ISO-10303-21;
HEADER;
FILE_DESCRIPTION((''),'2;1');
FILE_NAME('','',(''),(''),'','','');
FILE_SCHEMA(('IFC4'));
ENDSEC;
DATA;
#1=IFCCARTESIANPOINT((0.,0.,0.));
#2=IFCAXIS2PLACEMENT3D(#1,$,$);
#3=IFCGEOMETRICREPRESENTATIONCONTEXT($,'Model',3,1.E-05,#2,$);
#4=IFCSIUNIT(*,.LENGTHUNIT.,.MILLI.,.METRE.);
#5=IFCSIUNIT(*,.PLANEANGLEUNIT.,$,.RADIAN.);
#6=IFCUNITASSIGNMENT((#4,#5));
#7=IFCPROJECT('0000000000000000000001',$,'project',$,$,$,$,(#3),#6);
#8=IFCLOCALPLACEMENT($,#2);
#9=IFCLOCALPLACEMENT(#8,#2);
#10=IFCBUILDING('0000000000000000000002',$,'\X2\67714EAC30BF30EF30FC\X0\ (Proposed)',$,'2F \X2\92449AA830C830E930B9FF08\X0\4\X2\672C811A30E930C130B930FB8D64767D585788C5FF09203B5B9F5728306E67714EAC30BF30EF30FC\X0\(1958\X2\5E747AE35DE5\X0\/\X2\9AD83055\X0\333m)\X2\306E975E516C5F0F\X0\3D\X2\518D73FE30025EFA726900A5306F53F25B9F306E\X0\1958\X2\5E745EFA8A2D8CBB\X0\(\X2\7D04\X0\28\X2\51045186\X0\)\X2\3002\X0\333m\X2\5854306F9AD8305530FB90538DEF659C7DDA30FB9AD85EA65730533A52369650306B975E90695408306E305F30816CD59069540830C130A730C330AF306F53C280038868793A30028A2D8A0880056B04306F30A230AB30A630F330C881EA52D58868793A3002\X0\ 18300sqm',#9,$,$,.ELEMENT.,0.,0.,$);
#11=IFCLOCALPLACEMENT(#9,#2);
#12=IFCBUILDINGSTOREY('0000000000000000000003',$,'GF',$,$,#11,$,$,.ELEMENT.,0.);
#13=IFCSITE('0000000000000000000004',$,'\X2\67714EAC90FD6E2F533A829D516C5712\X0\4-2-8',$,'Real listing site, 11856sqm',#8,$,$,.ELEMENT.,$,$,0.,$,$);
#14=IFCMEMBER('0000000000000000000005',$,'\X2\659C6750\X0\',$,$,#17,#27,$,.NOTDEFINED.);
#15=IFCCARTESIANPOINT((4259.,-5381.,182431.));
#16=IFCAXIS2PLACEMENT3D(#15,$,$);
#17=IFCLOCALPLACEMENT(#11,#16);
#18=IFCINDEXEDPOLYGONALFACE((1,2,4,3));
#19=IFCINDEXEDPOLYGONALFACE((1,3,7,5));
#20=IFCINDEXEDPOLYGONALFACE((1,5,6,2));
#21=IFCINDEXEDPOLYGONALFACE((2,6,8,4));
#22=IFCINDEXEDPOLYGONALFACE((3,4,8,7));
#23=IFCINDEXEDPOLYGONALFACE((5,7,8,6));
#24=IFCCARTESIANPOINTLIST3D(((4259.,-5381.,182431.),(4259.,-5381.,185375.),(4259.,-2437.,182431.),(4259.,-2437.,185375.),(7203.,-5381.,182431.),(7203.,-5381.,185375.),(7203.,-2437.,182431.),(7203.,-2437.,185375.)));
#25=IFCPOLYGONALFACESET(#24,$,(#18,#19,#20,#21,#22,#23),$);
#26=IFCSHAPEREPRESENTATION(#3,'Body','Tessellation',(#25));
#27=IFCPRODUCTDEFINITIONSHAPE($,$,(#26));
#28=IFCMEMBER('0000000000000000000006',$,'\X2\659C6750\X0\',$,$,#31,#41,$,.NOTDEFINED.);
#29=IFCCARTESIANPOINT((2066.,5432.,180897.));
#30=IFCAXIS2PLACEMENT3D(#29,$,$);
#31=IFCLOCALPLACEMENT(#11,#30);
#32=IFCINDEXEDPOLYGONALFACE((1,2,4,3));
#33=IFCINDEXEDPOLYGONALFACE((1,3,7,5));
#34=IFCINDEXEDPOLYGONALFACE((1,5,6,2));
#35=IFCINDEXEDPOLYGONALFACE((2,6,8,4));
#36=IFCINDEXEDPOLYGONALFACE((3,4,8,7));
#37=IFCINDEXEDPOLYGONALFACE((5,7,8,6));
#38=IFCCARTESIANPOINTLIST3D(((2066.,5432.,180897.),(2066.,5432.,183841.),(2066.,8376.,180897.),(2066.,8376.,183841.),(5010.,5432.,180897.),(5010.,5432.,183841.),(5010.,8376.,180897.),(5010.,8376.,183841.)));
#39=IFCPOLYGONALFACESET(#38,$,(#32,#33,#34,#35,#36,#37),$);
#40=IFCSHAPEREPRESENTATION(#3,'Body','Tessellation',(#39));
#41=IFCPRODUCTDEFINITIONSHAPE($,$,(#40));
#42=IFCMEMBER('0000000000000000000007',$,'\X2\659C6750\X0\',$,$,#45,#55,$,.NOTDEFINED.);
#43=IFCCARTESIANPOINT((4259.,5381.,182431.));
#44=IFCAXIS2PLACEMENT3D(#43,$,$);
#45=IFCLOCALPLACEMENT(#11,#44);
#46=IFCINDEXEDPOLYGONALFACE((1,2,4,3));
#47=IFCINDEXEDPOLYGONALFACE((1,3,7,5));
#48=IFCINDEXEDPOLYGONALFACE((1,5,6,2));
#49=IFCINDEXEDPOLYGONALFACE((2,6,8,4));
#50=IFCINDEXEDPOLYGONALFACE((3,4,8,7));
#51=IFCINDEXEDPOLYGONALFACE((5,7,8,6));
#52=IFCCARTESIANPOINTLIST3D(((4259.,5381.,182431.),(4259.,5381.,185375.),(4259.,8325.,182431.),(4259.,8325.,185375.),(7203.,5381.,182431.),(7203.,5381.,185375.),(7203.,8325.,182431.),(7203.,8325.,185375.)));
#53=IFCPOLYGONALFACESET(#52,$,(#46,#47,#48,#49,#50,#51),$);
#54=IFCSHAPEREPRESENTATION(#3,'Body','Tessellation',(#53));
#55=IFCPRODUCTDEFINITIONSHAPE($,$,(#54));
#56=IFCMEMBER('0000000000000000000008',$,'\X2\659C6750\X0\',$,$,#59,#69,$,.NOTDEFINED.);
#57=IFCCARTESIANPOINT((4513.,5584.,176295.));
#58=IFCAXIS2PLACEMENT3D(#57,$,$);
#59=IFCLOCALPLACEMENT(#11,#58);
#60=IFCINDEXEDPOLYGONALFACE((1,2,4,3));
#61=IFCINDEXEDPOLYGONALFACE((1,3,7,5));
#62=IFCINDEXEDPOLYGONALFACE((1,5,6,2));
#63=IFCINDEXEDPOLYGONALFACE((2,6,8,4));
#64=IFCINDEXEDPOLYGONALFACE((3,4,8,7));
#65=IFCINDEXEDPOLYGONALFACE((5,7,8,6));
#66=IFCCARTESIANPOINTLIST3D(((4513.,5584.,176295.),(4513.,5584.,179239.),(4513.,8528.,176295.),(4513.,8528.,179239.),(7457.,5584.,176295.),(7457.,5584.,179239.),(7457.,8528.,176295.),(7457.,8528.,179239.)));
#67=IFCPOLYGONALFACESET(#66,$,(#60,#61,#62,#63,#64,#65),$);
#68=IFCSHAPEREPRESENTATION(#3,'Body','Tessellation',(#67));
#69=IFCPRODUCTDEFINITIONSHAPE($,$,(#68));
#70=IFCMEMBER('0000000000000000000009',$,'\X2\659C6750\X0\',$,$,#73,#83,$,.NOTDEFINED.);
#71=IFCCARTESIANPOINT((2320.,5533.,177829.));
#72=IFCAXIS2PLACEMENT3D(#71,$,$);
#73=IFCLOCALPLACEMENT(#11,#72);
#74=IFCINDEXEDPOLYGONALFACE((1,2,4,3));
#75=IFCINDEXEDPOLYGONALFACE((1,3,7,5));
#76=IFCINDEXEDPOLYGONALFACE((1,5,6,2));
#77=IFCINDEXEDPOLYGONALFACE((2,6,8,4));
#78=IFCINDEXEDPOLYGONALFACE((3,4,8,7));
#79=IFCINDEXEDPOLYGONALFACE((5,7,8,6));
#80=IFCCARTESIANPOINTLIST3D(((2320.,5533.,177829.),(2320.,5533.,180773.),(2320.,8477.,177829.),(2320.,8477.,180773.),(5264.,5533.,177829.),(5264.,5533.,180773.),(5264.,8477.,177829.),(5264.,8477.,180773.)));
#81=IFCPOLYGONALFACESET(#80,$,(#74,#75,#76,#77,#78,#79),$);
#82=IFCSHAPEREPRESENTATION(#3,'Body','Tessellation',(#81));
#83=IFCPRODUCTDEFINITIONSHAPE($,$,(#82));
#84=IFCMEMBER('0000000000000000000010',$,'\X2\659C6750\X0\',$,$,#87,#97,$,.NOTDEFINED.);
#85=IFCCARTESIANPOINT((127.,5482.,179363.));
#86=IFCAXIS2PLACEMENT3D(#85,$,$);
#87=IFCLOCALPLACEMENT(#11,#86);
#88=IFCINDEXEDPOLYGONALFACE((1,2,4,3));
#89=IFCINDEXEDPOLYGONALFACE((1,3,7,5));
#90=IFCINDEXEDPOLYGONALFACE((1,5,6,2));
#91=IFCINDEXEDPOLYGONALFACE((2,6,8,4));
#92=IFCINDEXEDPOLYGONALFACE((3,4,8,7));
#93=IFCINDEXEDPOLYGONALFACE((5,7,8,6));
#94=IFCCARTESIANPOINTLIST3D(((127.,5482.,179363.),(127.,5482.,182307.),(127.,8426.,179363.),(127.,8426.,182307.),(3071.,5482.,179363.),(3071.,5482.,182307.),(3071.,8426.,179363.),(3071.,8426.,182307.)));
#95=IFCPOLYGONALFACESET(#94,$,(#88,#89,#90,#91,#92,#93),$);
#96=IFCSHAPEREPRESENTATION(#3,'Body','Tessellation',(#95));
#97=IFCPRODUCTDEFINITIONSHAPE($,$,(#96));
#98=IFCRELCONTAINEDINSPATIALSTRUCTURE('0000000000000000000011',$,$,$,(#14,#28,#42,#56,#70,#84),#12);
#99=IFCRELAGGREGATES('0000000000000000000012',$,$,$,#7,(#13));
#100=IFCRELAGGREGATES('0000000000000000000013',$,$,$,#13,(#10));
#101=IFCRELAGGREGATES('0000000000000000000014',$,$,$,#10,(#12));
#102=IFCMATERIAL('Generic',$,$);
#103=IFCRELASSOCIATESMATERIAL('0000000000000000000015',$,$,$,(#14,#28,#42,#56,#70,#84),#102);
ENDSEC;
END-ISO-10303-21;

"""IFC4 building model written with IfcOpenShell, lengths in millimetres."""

from ifc_helpers import new_model, si_unit, frame, frame_2d, origin, place, context, project, spatial, rectangle, extrude, material, element, save


model = new_model("IFC4")

# Units and contexts
model_context = context("Model", 3, precision=1e-05, world=origin())
ifc_project = project(units=[si_unit("LENGTHUNIT", "METRE", prefix="MILLI"), si_unit("PLANEANGLEUNIT", "RADIAN")], contexts=[model_context])

# Site, building, storey
site_placement = place(None, origin())
site = spatial("IfcSite", under=ifc_project, at=site_placement, Name="東京都港区芝公園4-2-8", ObjectType="Real listing site, 11856sqm", CompositionType="ELEMENT", RefElevation=0.0)
building_placement = place(site_placement, origin())
building = spatial("IfcBuilding", under=site, at=building_placement, Name="東京タワー (Proposed)", ObjectType="2F 鉄骨トラス（4本脚ラチス・赤白塗装）※実在の東京タワー(1958年竣工/高さ333m)の非公式3D再現。建物¥は史実の1958年建設費(約28億円)。333m塔は高さ・道路斜線・高度地区制限に非適合のため法適合チェックは参考表示。設計者欄はアカウント自動表示。 18300sqm", CompositionType="ELEMENT", ElevationOfRefHeight=0.0, ElevationOfTerrain=0.0)
storey_placement = place(building_placement, origin())
storey = spatial("IfcBuildingStorey", under=building, at=storey_placement, Name="GF", CompositionType="ELEMENT", Elevation=0.0)

# Shared definitions
ifc_material = material(Name="Generic")

# Members
member_1_placement = place(storey_placement, frame((4259.0, -5381.0, 182431.0)))
element("IfcMember", 1, at=member_1_placement, inside=storey, material=ifc_material, Name="斜材", PredefinedType="NOTDEFINED", context=model_context, shape_type="SweptSolid", body=[
    extrude(rectangle(XDim=2944.0, YDim=2944.0, at=frame_2d((1472.0, 1472.0))), frame((4259.0, -5381.0, 182431.0)), (0.0, 0.0, 1.0), 2944.0),
])
member_2_placement = place(storey_placement, frame((2066.0, 5432.0, 180897.0)))
element("IfcMember", 2, at=member_2_placement, inside=storey, material=ifc_material, Name="斜材", PredefinedType="NOTDEFINED", context=model_context, shape_type="SweptSolid", body=[
    extrude(rectangle(XDim=2944.0, YDim=2944.0, at=frame_2d((1472.0, 1472.0))), frame((2066.0, 5432.0, 180897.0)), (0.0, 0.0, 1.0), 2944.0),
])
member_3_placement = place(storey_placement, frame((4259.0, 5381.0, 182431.0)))
element("IfcMember", 3, at=member_3_placement, inside=storey, material=ifc_material, Name="斜材", PredefinedType="NOTDEFINED", context=model_context, shape_type="SweptSolid", body=[
    extrude(rectangle(XDim=2944.0, YDim=2944.0, at=frame_2d((1472.0, 1472.0))), frame((4259.0, 5381.0, 182431.0)), (0.0, 0.0, 1.0), 2944.0),
])
member_4_placement = place(storey_placement, frame((4513.0, 5584.0, 176295.0)))
element("IfcMember", 4, at=member_4_placement, inside=storey, material=ifc_material, Name="斜材", PredefinedType="NOTDEFINED", context=model_context, shape_type="SweptSolid", body=[
    extrude(rectangle(XDim=2944.0, YDim=2944.0, at=frame_2d((1472.0, 1472.0))), frame((4513.0, 5584.0, 176295.0)), (0.0, 0.0, 1.0), 2944.0),
])
member_5_placement = place(storey_placement, frame((2320.0, 5533.0, 177829.0)))
element("IfcMember", 5, at=member_5_placement, inside=storey, material=ifc_material, Name="斜材", PredefinedType="NOTDEFINED", context=model_context, shape_type="SweptSolid", body=[
    extrude(rectangle(XDim=2944.0, YDim=2944.0, at=frame_2d((1472.0, 1472.0))), frame((2320.0, 5533.0, 177829.0)), (0.0, 0.0, 1.0), 2944.0),
])
member_6_placement = place(storey_placement, frame((127.0, 5482.0, 179363.0)))
element("IfcMember", 6, at=member_6_placement, inside=storey, material=ifc_material, Name="斜材", PredefinedType="NOTDEFINED", context=model_context, shape_type="SweptSolid", body=[
    extrude(rectangle(XDim=2944.0, YDim=2944.0, at=frame_2d((1472.0, 1472.0))), frame((127.0, 5482.0, 179363.0)), (0.0, 0.0, 1.0), 2944.0),
])

save(model, "model.ifc")
